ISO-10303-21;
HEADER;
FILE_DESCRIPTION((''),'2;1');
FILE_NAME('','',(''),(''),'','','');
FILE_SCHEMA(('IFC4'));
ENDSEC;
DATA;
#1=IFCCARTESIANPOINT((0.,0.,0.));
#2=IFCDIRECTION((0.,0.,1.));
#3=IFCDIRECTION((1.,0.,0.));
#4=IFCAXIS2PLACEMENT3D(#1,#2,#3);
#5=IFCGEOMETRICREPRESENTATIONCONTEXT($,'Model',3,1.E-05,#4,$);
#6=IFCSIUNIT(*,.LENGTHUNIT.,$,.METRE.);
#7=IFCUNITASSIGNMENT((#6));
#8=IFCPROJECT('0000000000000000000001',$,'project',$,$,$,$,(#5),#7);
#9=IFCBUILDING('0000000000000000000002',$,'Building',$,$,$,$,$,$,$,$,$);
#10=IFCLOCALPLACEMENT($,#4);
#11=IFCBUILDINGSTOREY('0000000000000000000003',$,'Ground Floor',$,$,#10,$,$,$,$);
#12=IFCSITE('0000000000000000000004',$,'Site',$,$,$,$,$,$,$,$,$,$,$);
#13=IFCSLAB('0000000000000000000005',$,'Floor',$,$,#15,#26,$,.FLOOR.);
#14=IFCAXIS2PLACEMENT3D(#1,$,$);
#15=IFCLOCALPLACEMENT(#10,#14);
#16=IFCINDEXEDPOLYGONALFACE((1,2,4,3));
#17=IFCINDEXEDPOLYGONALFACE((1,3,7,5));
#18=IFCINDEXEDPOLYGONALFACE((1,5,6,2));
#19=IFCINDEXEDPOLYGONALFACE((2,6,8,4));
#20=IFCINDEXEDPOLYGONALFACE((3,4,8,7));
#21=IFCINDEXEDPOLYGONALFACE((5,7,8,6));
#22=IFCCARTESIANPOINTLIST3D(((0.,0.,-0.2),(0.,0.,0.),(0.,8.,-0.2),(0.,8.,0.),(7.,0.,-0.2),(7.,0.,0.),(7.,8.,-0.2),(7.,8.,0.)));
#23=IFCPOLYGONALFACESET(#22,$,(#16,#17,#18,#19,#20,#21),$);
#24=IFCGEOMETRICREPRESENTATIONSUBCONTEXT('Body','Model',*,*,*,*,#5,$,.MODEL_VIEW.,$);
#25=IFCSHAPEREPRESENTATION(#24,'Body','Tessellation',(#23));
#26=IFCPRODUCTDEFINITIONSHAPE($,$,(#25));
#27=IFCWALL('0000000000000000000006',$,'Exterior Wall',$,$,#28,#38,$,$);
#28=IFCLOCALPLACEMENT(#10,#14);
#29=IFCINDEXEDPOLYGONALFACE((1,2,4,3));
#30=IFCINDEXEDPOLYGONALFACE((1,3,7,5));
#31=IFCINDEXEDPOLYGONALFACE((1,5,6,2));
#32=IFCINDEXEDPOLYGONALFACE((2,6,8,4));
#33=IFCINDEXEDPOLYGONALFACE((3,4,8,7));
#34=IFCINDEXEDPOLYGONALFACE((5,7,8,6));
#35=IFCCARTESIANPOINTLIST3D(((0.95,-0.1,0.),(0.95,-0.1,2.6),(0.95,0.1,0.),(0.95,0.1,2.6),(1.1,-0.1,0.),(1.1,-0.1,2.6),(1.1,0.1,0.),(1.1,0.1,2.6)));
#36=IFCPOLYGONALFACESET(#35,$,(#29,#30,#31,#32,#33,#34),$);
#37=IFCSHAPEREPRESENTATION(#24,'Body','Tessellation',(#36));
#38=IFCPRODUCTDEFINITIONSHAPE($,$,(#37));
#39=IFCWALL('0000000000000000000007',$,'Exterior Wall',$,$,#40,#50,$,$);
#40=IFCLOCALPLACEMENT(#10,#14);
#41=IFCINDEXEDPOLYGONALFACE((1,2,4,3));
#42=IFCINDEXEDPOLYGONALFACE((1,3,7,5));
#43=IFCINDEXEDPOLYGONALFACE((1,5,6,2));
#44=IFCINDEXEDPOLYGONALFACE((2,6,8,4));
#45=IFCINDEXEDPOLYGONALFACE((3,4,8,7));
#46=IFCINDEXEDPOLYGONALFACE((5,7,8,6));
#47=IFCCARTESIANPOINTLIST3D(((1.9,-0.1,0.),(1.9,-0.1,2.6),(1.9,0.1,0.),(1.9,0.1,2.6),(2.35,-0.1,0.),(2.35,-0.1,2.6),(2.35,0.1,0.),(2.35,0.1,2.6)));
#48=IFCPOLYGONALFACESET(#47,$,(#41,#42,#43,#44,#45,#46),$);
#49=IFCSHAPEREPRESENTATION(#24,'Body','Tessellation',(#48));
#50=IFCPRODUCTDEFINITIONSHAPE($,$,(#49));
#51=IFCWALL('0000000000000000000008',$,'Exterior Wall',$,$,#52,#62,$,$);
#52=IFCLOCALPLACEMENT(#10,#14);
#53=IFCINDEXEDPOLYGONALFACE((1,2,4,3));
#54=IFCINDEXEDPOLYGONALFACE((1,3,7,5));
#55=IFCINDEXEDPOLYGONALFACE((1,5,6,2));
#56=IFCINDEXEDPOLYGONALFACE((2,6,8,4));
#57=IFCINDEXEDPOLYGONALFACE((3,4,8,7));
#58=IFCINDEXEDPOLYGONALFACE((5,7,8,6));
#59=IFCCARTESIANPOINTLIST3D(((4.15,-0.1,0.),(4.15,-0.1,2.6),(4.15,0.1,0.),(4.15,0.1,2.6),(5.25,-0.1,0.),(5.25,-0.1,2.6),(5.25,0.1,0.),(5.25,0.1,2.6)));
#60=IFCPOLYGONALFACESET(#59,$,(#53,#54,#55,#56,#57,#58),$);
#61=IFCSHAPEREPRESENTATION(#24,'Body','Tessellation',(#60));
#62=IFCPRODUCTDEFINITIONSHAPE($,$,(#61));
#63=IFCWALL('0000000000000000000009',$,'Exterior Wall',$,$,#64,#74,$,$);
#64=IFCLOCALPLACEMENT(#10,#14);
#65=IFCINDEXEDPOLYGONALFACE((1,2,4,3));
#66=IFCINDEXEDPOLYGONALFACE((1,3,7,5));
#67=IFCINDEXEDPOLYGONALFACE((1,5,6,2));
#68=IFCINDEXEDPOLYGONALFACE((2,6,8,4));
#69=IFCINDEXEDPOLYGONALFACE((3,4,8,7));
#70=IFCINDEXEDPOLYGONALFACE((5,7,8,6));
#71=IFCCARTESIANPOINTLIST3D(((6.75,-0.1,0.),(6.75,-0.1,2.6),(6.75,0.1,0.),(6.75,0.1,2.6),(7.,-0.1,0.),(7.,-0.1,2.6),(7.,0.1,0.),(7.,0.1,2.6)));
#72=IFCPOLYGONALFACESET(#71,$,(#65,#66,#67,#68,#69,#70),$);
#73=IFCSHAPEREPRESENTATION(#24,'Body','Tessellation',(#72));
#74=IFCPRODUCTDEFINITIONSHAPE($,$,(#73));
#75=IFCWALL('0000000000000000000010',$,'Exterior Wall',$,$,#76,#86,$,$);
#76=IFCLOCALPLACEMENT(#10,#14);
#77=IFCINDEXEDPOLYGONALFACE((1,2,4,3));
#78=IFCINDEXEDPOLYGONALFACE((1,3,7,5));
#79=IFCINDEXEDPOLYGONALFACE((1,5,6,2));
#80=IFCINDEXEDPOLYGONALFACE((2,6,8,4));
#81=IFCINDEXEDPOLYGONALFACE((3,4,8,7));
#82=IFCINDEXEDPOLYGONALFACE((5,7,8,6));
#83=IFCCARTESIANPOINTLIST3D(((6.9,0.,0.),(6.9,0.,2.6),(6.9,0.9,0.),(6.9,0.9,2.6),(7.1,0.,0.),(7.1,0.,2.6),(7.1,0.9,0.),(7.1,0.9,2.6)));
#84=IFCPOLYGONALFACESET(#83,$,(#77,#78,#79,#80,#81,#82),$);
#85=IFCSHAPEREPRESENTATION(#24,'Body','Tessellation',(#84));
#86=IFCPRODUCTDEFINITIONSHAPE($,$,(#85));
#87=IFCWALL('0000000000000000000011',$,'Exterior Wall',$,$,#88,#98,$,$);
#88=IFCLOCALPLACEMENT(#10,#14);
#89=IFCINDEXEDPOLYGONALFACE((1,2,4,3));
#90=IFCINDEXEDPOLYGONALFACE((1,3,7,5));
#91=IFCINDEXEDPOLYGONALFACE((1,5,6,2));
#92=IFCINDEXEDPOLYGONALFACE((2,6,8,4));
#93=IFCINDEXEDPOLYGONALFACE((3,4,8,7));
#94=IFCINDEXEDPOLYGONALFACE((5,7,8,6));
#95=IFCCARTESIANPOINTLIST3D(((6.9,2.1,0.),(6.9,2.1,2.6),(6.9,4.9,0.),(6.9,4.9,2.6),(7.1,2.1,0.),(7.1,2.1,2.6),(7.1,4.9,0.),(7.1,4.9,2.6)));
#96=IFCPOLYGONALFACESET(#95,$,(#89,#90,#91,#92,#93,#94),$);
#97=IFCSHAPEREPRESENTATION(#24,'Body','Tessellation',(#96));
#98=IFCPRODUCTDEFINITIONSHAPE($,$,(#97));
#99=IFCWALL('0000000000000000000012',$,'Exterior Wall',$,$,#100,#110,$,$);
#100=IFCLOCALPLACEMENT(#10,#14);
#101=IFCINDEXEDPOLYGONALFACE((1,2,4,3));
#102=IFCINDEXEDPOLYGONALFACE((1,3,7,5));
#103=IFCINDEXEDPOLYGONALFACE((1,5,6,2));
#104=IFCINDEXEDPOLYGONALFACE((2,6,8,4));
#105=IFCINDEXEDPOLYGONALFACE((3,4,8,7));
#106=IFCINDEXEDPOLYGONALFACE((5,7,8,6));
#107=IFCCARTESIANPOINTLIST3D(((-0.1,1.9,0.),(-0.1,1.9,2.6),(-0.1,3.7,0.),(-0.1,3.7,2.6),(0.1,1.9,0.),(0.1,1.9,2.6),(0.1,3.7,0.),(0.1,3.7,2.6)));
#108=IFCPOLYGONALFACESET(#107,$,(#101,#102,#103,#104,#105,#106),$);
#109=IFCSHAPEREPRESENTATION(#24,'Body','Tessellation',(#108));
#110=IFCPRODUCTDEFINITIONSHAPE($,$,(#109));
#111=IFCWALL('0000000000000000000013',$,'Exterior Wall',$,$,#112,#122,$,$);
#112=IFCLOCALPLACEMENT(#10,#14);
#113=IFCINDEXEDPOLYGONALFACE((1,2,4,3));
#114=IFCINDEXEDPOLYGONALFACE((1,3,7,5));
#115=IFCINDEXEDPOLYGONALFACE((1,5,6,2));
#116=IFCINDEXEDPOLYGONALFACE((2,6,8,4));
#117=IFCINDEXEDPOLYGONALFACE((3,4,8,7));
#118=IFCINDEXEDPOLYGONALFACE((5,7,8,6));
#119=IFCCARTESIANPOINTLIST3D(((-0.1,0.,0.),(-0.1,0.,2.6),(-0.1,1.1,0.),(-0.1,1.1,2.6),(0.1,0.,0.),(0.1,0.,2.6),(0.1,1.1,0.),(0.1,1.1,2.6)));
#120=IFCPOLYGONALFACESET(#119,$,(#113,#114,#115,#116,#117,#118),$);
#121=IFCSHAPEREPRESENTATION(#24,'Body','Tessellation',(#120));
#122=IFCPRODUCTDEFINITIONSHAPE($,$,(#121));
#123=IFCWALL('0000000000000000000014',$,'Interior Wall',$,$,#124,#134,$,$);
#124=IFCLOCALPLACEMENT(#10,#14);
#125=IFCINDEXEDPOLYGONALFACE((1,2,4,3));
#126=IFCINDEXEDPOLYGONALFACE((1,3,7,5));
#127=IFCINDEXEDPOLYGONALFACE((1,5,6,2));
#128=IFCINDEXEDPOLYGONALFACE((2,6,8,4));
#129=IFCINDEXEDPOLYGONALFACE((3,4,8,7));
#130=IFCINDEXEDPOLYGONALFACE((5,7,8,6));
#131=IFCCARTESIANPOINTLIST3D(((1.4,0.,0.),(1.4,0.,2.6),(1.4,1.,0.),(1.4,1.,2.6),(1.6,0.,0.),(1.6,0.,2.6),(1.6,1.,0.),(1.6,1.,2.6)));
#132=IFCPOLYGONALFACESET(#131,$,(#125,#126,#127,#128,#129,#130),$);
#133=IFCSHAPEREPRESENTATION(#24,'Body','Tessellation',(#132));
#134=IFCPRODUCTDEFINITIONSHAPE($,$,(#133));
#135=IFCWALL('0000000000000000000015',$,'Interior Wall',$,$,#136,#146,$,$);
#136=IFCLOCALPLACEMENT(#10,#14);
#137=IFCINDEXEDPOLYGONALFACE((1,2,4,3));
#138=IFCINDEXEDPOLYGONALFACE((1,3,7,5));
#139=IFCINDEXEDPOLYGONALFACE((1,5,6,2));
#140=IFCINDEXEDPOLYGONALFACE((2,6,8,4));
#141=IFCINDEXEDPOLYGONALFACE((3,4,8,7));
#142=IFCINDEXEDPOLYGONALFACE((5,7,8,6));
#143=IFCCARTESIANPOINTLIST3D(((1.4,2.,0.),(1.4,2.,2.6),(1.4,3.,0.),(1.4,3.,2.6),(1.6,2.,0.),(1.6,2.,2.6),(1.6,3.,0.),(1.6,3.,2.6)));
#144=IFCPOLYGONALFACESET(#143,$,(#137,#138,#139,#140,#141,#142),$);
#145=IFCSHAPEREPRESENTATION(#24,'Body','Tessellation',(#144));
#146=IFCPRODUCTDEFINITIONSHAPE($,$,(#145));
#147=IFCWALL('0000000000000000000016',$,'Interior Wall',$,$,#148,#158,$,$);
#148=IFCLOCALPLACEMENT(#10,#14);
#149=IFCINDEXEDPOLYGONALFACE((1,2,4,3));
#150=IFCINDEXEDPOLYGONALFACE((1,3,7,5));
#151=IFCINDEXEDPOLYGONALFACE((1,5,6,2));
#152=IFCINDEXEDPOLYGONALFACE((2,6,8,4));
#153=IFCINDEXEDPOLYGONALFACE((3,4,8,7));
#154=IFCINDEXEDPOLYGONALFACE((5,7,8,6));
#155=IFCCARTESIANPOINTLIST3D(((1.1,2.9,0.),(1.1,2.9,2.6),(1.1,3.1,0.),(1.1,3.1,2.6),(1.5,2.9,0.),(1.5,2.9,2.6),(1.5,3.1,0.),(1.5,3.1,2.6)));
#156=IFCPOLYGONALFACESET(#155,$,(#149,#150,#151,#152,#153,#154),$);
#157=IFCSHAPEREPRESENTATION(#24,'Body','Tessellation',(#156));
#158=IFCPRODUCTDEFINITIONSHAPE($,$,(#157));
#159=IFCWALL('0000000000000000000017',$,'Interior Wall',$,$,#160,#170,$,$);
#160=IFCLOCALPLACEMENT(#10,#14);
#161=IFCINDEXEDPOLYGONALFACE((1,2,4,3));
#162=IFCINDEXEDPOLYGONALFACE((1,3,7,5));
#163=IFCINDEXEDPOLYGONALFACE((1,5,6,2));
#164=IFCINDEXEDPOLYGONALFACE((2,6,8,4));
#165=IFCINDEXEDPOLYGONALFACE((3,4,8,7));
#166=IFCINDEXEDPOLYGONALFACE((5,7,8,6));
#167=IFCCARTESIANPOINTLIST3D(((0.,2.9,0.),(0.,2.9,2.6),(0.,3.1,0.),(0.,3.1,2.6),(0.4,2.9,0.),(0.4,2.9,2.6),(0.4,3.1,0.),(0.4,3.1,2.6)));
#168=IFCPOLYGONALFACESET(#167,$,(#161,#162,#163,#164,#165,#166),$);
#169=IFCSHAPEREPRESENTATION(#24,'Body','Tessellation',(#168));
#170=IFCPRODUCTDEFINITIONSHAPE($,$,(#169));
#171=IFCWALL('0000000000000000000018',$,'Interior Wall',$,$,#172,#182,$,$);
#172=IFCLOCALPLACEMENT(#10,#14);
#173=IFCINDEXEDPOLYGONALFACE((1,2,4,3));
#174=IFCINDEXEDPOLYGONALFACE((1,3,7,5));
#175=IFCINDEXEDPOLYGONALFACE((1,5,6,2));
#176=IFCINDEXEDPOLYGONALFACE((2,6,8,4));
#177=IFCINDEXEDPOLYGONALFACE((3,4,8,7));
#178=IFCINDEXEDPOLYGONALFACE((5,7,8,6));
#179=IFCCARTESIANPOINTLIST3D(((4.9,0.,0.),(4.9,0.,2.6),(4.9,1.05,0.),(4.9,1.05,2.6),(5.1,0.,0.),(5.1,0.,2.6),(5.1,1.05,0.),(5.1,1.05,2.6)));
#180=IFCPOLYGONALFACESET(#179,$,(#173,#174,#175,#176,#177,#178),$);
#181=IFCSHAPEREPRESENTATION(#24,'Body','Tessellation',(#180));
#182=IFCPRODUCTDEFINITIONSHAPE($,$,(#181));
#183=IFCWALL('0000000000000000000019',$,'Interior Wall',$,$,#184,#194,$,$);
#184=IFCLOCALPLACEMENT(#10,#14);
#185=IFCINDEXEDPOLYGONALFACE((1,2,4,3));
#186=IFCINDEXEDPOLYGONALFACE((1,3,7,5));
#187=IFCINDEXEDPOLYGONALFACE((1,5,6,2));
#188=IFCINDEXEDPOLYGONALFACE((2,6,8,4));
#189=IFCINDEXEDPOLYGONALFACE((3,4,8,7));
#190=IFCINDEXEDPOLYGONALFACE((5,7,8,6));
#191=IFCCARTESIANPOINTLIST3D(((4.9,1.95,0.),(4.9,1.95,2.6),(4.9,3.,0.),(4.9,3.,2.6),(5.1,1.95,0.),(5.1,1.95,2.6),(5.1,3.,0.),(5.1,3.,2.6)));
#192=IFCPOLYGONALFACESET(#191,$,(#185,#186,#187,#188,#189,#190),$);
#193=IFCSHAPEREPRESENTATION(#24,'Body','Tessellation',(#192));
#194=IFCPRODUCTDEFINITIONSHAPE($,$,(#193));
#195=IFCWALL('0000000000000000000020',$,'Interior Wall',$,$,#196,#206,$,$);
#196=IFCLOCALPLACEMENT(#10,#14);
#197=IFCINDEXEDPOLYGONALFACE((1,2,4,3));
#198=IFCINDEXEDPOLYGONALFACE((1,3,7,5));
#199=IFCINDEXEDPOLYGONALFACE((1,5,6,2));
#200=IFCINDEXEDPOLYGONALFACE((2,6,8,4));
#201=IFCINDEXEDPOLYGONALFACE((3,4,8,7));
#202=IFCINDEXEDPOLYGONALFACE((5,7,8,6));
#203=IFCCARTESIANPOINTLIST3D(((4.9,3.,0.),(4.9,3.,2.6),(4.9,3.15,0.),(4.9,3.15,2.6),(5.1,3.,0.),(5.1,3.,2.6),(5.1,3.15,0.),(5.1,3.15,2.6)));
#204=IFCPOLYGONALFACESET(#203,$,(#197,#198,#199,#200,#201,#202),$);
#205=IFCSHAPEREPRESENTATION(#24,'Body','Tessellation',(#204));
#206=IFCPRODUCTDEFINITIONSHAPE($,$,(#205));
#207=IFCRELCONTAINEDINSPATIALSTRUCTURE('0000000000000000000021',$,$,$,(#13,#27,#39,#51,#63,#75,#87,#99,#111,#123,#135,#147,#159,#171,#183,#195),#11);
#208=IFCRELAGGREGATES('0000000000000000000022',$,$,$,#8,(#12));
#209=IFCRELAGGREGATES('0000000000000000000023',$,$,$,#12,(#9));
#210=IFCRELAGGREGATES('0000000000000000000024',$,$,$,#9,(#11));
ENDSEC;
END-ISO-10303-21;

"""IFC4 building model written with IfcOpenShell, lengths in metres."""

from ifc_helpers import new_model, si_unit, frame, origin_with_axes, place, context, subcontext, project, spatial, indexed_curve, outline, extrude, element, save


model = new_model("IFC4")

# Units and contexts
model_context = context("Model", 3, precision=1e-05, world=origin_with_axes())
body_context = subcontext(model_context, "Body", "Model", "MODEL_VIEW")
ifc_project = project(units=[si_unit("LENGTHUNIT", "METRE")], contexts=[model_context])

# Site, building, storey
site = spatial("IfcSite", under=ifc_project, Name="Site")
building = spatial("IfcBuilding", under=site, Name="Building")
storey_placement = place(None, origin_with_axes())
storey = spatial("IfcBuildingStorey", under=building, at=storey_placement, Name="Ground Floor")

# Slab
slab_placement = place(storey_placement, frame((0.0, 0.0, -0.2), z_axis=(0.0, 0.0, 1.0), x_axis=(1.0, 0.0, 0.0)))
element("IfcSlab", 1, at=slab_placement, inside=storey, Name="Floor", PredefinedType="FLOOR", context=body_context, shape_type="SweptSolid", body=[
    extrude(outline(indexed_curve([(0.0, 0.0), (7.0, 0.0), (7.0, 8.0), (0.0, 8.0)])), None, (0.0, 0.0, 1.0), 0.2),
])

# Walls
wall_1_placement = place(storey_placement, frame((0.95, 0.0, 0.0), z_axis=(0.0, 0.0, 1.0), x_axis=(1.0, 0.0, 0.0)))
element("IfcWall", 2, at=wall_1_placement, inside=storey, Name="Exterior Wall", context=body_context, shape_type="SweptSolid", body=[
    extrude(outline(indexed_curve([(0.0, 0.0), (0.0, 0.2), (0.15, 0.2), (0.15, 0.0), (0.0, 0.0)], self_intersect=False)), frame((0.0, -0.1, 0.0), z_axis=(0.0, 0.0, 1.0), x_axis=(1.0, 0.0, 0.0)), (0.0, 0.0, 1.0), 2.6),
])
wall_2_placement = place(storey_placement, frame((1.9, 0.0, 0.0), z_axis=(0.0, 0.0, 1.0), x_axis=(1.0, 0.0, 0.0)))
element("IfcWall", 3, at=wall_2_placement, inside=storey, Name="Exterior Wall", context=body_context, shape_type="SweptSolid", body=[
    extrude(outline(indexed_curve([(0.0, 0.0), (0.0, 0.2), (0.45, 0.2), (0.45, 0.0), (0.0, 0.0)], self_intersect=False)), frame((0.0, -0.1, 0.0), z_axis=(0.0, 0.0, 1.0), x_axis=(1.0, 0.0, 0.0)), (0.0, 0.0, 1.0), 2.6),
])
wall_3_placement = place(storey_placement, frame((4.15, 0.0, 0.0), z_axis=(0.0, 0.0, 1.0), x_axis=(1.0, 0.0, 0.0)))
element("IfcWall", 4, at=wall_3_placement, inside=storey, Name="Exterior Wall", context=body_context, shape_type="SweptSolid", body=[
    extrude(outline(indexed_curve([(0.0, 0.0), (0.0, 0.2), (1.1, 0.2), (1.1, 0.0), (0.0, 0.0)], self_intersect=False)), frame((0.0, -0.1, 0.0), z_axis=(0.0, 0.0, 1.0), x_axis=(1.0, 0.0, 0.0)), (0.0, 0.0, 1.0), 2.6),
])
wall_4_placement = place(storey_placement, frame((6.75, 0.0, 0.0), z_axis=(0.0, 0.0, 1.0), x_axis=(1.0, 0.0, 0.0)))
element("IfcWall", 5, at=wall_4_placement, inside=storey, Name="Exterior Wall", context=body_context, shape_type="SweptSolid", body=[
    extrude(outline(indexed_curve([(0.0, 0.0), (0.0, 0.2), (0.25, 0.2), (0.25, 0.0), (0.0, 0.0)], self_intersect=False)), frame((0.0, -0.1, 0.0), z_axis=(0.0, 0.0, 1.0), x_axis=(1.0, 0.0, 0.0)), (0.0, 0.0, 1.0), 2.6),
])
wall_5_placement = place(storey_placement, frame((7.0, 0.0, 0.0), z_axis=(0.0, 0.0, 1.0), x_axis=(0.0, 1.0, 0.0)))
element("IfcWall", 6, at=wall_5_placement, inside=storey, Name="Exterior Wall", context=body_context, shape_type="SweptSolid", body=[
    extrude(outline(indexed_curve([(0.0, 0.0), (0.0, 0.2), (0.9, 0.2), (0.9, 0.0), (0.0, 0.0)], self_intersect=False)), frame((0.0, -0.1, 0.0), z_axis=(0.0, 0.0, 1.0), x_axis=(1.0, 0.0, 0.0)), (0.0, 0.0, 1.0), 2.6),
])
wall_6_placement = place(storey_placement, frame((7.0, 2.1, 0.0), z_axis=(0.0, 0.0, 1.0), x_axis=(0.0, 1.0, 0.0)))
element("IfcWall", 7, at=wall_6_placement, inside=storey, Name="Exterior Wall", context=body_context, shape_type="SweptSolid", body=[
    extrude(outline(indexed_curve([(0.0, 0.0), (0.0, 0.2), (2.8, 0.2), (2.8, 0.0), (0.0, 0.0)], self_intersect=False)), frame((0.0, -0.1, 0.0), z_axis=(0.0, 0.0, 1.0), x_axis=(1.0, 0.0, 0.0)), (0.0, 0.0, 1.0), 2.6),
])
wall_7_placement = place(storey_placement, frame((0.0, 3.7, 0.0), z_axis=(0.0, 0.0, 1.0), x_axis=(0.0, -1.0, 0.0)))
element("IfcWall", 8, at=wall_7_placement, inside=storey, Name="Exterior Wall", context=body_context, shape_type="SweptSolid", body=[
    extrude(outline(indexed_curve([(0.0, 0.0), (0.0, 0.2), (1.8, 0.2), (1.8, 0.0), (0.0, 0.0)], self_intersect=False)), frame((0.0, -0.1, 0.0), z_axis=(0.0, 0.0, 1.0), x_axis=(1.0, 0.0, 0.0)), (0.0, 0.0, 1.0), 2.6),
])
wall_8_placement = place(storey_placement, frame((0.0, 1.1, 0.0), z_axis=(0.0, 0.0, 1.0), x_axis=(0.0, -1.0, 0.0)))
element("IfcWall", 9, at=wall_8_placement, inside=storey, Name="Exterior Wall", context=body_context, shape_type="SweptSolid", body=[
    extrude(outline(indexed_curve([(0.0, 0.0), (0.0, 0.2), (1.1, 0.2), (1.1, 0.0), (0.0, 0.0)], self_intersect=False)), frame((0.0, -0.1, 0.0), z_axis=(0.0, 0.0, 1.0), x_axis=(1.0, 0.0, 0.0)), (0.0, 0.0, 1.0), 2.6),
])
for number, where, z_axis, x_axis, name in (
    (10, (1.5, 0.0, 0.0), (0.0, 0.0, 1.0), (0.0, 1.0, 0.0), "Interior Wall"),
    (11, (1.5, 2.0, 0.0), (0.0, 0.0, 1.0), (0.0, 1.0, 0.0), "Interior Wall"),
):
    element("IfcWall", number, at=place(storey_placement, frame(where, z_axis=z_axis, x_axis=x_axis)), inside=storey, Name=name, context=body_context, shape_type="SweptSolid", body=[
        extrude(outline(indexed_curve([(0.0, 0.0), (0.0, 0.2), (1.0, 0.2), (1.0, 0.0), (0.0, 0.0)], self_intersect=False)), frame((0.0, -0.1, 0.0), z_axis=(0.0, 0.0, 1.0), x_axis=(1.0, 0.0, 0.0)), (0.0, 0.0, 1.0), 2.6),
    ])
for number, where, z_axis, x_axis, name in (
    (12, (1.5, 3.0, 0.0), (0.0, 0.0, 1.0), (-1.0, 0.0, 0.0), "Interior Wall"),
    (13, (0.4, 3.0, 0.0), (0.0, 0.0, 1.0), (-1.0, 0.0, 0.0), "Interior Wall"),
):
    element("IfcWall", number, at=place(storey_placement, frame(where, z_axis=z_axis, x_axis=x_axis)), inside=storey, Name=name, context=body_context, shape_type="SweptSolid", body=[
        extrude(outline(indexed_curve([(0.0, 0.0), (0.0, 0.2), (0.4, 0.2), (0.4, 0.0), (0.0, 0.0)], self_intersect=False)), frame((0.0, -0.1, 0.0), z_axis=(0.0, 0.0, 1.0), x_axis=(1.0, 0.0, 0.0)), (0.0, 0.0, 1.0), 2.6),
    ])
for number, where, z_axis, x_axis, name in (
    (14, (5.0, 0.0, 0.0), (0.0, 0.0, 1.0), (0.0, 1.0, 0.0), "Interior Wall"),
    (15, (5.0, 1.95, 0.0), (0.0, 0.0, 1.0), (0.0, 1.0, 0.0), "Interior Wall"),
):
    element("IfcWall", number, at=place(storey_placement, frame(where, z_axis=z_axis, x_axis=x_axis)), inside=storey, Name=name, context=body_context, shape_type="SweptSolid", body=[
        extrude(outline(indexed_curve([(0.0, 0.0), (0.0, 0.2), (1.05, 0.2), (1.05, 0.0), (0.0, 0.0)], self_intersect=False)), frame((0.0, -0.1, 0.0), z_axis=(0.0, 0.0, 1.0), x_axis=(1.0, 0.0, 0.0)), (0.0, 0.0, 1.0), 2.6),
    ])
for number, where, z_axis, x_axis, name in (
    (16, (5.0, 3.0, 0.0), (0.0, 0.0, 1.0), (0.0, 1.0, 0.0), "Interior Wall"),
):
    element("IfcWall", number, at=place(storey_placement, frame(where, z_axis=z_axis, x_axis=x_axis)), inside=storey, Name=name, context=body_context, shape_type="SweptSolid", body=[
        extrude(outline(indexed_curve([(0.0, 0.0), (0.0, 0.2), (0.15, 0.2), (0.15, 0.0), (0.0, 0.0)], self_intersect=False)), frame((0.0, -0.1, 0.0), z_axis=(0.0, 0.0, 1.0), x_axis=(1.0, 0.0, 0.0)), (0.0, 0.0, 1.0), 2.6),
    ])

save(model, "model.ifc")
